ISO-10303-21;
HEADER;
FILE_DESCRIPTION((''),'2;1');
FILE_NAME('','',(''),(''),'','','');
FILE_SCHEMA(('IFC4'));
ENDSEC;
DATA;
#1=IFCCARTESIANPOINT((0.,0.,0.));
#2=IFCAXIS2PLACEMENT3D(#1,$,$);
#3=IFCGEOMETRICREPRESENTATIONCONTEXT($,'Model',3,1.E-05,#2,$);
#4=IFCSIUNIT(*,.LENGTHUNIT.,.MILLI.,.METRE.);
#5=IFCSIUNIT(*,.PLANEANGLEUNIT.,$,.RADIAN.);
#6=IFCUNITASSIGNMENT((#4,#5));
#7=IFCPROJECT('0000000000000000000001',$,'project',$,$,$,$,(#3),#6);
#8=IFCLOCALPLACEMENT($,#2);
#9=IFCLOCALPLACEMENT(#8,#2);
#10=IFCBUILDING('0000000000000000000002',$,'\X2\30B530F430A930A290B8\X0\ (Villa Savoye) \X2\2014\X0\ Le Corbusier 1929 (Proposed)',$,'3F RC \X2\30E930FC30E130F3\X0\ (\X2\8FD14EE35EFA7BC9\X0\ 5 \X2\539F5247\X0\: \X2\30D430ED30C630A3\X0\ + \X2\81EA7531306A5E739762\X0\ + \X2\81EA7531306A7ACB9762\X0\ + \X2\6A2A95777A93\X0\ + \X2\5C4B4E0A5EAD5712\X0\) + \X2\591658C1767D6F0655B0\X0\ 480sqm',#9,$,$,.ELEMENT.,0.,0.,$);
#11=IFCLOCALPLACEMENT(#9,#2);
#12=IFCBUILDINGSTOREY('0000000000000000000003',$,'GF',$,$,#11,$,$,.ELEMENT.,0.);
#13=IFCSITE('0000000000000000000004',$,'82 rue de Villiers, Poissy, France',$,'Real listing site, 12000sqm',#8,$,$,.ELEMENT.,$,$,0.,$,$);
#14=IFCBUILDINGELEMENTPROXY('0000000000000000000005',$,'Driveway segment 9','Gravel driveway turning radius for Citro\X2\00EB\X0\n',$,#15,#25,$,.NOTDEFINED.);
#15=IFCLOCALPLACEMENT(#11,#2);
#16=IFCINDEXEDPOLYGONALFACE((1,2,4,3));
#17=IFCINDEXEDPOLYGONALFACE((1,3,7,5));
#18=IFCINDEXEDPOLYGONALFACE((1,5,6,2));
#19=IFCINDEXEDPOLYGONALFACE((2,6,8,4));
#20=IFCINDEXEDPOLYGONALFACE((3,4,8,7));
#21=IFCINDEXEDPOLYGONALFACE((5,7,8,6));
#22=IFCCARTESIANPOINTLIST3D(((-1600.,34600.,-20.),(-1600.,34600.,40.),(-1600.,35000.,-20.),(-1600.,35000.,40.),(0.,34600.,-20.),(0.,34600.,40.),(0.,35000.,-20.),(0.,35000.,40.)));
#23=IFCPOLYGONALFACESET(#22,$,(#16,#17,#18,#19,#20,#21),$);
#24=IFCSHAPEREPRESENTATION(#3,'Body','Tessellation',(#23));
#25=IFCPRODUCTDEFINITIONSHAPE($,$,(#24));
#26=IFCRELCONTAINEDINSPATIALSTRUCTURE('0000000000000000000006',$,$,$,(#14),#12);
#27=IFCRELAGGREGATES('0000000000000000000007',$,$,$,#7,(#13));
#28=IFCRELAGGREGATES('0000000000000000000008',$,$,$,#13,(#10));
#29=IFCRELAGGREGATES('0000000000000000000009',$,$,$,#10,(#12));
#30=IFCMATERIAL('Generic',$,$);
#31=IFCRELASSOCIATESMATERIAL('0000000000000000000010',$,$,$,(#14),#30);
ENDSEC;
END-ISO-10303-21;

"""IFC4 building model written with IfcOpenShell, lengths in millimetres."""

from ifc_helpers import new_model, si_unit, frame, frame_2d, origin, place, context, project, spatial, rectangle, extrude, material, element, save


model = new_model("IFC4")

# Units and contexts
model_context = context("Model", 3, precision=1e-05, world=origin())
ifc_project = project(units=[si_unit("LENGTHUNIT", "METRE", prefix="MILLI"), si_unit("PLANEANGLEUNIT", "RADIAN")], contexts=[model_context])

# Site, building, storey
site_placement = place(None, origin())
site = spatial("IfcSite", under=ifc_project, at=site_placement, Name="82 rue de Villiers, Poissy, France", ObjectType="Real listing site, 12000sqm", CompositionType="ELEMENT", RefElevation=0.0)
building_placement = place(site_placement, origin())
building = spatial("IfcBuilding", under=site, at=building_placement, Name="サヴォア邸 (Villa Savoye) — Le Corbusier 1929 (Proposed)", ObjectType="3F RC ラーメン (近代建築 5 原則: ピロティ + 自由な平面 + 自由な立面 + 横長窓 + 屋上庭園) + 外壁白漆喰 480sqm", CompositionType="ELEMENT", ElevationOfRefHeight=0.0, ElevationOfTerrain=0.0)
storey_placement = place(building_placement, origin())
storey = spatial("IfcBuildingStorey", under=building, at=storey_placement, Name="GF", CompositionType="ELEMENT", Elevation=0.0)

# Shared definitions
ifc_material_1 = material(Name="Generic")

# Building element proxy
proxy_1_placement = place(storey_placement, frame((-800.0, 17300.0, -10.0)))
element("IfcBuildingElementProxy", 1, at=proxy_1_placement, inside=storey, material=ifc_material_1, Name="Driveway segment 9", Description="Gravel driveway turning radius for Citroën", PredefinedType="NOTDEFINED", context=model_context, shape_type="SweptSolid", body=[
    extrude(rectangle(XDim=1600.0, YDim=400.0, at=frame_2d((800.0, 200.0))), frame((-800.0, 17300.0, -10.0)), (0.0, 0.0, 1.0), 60.0),
])

save(model, "model.ifc")
